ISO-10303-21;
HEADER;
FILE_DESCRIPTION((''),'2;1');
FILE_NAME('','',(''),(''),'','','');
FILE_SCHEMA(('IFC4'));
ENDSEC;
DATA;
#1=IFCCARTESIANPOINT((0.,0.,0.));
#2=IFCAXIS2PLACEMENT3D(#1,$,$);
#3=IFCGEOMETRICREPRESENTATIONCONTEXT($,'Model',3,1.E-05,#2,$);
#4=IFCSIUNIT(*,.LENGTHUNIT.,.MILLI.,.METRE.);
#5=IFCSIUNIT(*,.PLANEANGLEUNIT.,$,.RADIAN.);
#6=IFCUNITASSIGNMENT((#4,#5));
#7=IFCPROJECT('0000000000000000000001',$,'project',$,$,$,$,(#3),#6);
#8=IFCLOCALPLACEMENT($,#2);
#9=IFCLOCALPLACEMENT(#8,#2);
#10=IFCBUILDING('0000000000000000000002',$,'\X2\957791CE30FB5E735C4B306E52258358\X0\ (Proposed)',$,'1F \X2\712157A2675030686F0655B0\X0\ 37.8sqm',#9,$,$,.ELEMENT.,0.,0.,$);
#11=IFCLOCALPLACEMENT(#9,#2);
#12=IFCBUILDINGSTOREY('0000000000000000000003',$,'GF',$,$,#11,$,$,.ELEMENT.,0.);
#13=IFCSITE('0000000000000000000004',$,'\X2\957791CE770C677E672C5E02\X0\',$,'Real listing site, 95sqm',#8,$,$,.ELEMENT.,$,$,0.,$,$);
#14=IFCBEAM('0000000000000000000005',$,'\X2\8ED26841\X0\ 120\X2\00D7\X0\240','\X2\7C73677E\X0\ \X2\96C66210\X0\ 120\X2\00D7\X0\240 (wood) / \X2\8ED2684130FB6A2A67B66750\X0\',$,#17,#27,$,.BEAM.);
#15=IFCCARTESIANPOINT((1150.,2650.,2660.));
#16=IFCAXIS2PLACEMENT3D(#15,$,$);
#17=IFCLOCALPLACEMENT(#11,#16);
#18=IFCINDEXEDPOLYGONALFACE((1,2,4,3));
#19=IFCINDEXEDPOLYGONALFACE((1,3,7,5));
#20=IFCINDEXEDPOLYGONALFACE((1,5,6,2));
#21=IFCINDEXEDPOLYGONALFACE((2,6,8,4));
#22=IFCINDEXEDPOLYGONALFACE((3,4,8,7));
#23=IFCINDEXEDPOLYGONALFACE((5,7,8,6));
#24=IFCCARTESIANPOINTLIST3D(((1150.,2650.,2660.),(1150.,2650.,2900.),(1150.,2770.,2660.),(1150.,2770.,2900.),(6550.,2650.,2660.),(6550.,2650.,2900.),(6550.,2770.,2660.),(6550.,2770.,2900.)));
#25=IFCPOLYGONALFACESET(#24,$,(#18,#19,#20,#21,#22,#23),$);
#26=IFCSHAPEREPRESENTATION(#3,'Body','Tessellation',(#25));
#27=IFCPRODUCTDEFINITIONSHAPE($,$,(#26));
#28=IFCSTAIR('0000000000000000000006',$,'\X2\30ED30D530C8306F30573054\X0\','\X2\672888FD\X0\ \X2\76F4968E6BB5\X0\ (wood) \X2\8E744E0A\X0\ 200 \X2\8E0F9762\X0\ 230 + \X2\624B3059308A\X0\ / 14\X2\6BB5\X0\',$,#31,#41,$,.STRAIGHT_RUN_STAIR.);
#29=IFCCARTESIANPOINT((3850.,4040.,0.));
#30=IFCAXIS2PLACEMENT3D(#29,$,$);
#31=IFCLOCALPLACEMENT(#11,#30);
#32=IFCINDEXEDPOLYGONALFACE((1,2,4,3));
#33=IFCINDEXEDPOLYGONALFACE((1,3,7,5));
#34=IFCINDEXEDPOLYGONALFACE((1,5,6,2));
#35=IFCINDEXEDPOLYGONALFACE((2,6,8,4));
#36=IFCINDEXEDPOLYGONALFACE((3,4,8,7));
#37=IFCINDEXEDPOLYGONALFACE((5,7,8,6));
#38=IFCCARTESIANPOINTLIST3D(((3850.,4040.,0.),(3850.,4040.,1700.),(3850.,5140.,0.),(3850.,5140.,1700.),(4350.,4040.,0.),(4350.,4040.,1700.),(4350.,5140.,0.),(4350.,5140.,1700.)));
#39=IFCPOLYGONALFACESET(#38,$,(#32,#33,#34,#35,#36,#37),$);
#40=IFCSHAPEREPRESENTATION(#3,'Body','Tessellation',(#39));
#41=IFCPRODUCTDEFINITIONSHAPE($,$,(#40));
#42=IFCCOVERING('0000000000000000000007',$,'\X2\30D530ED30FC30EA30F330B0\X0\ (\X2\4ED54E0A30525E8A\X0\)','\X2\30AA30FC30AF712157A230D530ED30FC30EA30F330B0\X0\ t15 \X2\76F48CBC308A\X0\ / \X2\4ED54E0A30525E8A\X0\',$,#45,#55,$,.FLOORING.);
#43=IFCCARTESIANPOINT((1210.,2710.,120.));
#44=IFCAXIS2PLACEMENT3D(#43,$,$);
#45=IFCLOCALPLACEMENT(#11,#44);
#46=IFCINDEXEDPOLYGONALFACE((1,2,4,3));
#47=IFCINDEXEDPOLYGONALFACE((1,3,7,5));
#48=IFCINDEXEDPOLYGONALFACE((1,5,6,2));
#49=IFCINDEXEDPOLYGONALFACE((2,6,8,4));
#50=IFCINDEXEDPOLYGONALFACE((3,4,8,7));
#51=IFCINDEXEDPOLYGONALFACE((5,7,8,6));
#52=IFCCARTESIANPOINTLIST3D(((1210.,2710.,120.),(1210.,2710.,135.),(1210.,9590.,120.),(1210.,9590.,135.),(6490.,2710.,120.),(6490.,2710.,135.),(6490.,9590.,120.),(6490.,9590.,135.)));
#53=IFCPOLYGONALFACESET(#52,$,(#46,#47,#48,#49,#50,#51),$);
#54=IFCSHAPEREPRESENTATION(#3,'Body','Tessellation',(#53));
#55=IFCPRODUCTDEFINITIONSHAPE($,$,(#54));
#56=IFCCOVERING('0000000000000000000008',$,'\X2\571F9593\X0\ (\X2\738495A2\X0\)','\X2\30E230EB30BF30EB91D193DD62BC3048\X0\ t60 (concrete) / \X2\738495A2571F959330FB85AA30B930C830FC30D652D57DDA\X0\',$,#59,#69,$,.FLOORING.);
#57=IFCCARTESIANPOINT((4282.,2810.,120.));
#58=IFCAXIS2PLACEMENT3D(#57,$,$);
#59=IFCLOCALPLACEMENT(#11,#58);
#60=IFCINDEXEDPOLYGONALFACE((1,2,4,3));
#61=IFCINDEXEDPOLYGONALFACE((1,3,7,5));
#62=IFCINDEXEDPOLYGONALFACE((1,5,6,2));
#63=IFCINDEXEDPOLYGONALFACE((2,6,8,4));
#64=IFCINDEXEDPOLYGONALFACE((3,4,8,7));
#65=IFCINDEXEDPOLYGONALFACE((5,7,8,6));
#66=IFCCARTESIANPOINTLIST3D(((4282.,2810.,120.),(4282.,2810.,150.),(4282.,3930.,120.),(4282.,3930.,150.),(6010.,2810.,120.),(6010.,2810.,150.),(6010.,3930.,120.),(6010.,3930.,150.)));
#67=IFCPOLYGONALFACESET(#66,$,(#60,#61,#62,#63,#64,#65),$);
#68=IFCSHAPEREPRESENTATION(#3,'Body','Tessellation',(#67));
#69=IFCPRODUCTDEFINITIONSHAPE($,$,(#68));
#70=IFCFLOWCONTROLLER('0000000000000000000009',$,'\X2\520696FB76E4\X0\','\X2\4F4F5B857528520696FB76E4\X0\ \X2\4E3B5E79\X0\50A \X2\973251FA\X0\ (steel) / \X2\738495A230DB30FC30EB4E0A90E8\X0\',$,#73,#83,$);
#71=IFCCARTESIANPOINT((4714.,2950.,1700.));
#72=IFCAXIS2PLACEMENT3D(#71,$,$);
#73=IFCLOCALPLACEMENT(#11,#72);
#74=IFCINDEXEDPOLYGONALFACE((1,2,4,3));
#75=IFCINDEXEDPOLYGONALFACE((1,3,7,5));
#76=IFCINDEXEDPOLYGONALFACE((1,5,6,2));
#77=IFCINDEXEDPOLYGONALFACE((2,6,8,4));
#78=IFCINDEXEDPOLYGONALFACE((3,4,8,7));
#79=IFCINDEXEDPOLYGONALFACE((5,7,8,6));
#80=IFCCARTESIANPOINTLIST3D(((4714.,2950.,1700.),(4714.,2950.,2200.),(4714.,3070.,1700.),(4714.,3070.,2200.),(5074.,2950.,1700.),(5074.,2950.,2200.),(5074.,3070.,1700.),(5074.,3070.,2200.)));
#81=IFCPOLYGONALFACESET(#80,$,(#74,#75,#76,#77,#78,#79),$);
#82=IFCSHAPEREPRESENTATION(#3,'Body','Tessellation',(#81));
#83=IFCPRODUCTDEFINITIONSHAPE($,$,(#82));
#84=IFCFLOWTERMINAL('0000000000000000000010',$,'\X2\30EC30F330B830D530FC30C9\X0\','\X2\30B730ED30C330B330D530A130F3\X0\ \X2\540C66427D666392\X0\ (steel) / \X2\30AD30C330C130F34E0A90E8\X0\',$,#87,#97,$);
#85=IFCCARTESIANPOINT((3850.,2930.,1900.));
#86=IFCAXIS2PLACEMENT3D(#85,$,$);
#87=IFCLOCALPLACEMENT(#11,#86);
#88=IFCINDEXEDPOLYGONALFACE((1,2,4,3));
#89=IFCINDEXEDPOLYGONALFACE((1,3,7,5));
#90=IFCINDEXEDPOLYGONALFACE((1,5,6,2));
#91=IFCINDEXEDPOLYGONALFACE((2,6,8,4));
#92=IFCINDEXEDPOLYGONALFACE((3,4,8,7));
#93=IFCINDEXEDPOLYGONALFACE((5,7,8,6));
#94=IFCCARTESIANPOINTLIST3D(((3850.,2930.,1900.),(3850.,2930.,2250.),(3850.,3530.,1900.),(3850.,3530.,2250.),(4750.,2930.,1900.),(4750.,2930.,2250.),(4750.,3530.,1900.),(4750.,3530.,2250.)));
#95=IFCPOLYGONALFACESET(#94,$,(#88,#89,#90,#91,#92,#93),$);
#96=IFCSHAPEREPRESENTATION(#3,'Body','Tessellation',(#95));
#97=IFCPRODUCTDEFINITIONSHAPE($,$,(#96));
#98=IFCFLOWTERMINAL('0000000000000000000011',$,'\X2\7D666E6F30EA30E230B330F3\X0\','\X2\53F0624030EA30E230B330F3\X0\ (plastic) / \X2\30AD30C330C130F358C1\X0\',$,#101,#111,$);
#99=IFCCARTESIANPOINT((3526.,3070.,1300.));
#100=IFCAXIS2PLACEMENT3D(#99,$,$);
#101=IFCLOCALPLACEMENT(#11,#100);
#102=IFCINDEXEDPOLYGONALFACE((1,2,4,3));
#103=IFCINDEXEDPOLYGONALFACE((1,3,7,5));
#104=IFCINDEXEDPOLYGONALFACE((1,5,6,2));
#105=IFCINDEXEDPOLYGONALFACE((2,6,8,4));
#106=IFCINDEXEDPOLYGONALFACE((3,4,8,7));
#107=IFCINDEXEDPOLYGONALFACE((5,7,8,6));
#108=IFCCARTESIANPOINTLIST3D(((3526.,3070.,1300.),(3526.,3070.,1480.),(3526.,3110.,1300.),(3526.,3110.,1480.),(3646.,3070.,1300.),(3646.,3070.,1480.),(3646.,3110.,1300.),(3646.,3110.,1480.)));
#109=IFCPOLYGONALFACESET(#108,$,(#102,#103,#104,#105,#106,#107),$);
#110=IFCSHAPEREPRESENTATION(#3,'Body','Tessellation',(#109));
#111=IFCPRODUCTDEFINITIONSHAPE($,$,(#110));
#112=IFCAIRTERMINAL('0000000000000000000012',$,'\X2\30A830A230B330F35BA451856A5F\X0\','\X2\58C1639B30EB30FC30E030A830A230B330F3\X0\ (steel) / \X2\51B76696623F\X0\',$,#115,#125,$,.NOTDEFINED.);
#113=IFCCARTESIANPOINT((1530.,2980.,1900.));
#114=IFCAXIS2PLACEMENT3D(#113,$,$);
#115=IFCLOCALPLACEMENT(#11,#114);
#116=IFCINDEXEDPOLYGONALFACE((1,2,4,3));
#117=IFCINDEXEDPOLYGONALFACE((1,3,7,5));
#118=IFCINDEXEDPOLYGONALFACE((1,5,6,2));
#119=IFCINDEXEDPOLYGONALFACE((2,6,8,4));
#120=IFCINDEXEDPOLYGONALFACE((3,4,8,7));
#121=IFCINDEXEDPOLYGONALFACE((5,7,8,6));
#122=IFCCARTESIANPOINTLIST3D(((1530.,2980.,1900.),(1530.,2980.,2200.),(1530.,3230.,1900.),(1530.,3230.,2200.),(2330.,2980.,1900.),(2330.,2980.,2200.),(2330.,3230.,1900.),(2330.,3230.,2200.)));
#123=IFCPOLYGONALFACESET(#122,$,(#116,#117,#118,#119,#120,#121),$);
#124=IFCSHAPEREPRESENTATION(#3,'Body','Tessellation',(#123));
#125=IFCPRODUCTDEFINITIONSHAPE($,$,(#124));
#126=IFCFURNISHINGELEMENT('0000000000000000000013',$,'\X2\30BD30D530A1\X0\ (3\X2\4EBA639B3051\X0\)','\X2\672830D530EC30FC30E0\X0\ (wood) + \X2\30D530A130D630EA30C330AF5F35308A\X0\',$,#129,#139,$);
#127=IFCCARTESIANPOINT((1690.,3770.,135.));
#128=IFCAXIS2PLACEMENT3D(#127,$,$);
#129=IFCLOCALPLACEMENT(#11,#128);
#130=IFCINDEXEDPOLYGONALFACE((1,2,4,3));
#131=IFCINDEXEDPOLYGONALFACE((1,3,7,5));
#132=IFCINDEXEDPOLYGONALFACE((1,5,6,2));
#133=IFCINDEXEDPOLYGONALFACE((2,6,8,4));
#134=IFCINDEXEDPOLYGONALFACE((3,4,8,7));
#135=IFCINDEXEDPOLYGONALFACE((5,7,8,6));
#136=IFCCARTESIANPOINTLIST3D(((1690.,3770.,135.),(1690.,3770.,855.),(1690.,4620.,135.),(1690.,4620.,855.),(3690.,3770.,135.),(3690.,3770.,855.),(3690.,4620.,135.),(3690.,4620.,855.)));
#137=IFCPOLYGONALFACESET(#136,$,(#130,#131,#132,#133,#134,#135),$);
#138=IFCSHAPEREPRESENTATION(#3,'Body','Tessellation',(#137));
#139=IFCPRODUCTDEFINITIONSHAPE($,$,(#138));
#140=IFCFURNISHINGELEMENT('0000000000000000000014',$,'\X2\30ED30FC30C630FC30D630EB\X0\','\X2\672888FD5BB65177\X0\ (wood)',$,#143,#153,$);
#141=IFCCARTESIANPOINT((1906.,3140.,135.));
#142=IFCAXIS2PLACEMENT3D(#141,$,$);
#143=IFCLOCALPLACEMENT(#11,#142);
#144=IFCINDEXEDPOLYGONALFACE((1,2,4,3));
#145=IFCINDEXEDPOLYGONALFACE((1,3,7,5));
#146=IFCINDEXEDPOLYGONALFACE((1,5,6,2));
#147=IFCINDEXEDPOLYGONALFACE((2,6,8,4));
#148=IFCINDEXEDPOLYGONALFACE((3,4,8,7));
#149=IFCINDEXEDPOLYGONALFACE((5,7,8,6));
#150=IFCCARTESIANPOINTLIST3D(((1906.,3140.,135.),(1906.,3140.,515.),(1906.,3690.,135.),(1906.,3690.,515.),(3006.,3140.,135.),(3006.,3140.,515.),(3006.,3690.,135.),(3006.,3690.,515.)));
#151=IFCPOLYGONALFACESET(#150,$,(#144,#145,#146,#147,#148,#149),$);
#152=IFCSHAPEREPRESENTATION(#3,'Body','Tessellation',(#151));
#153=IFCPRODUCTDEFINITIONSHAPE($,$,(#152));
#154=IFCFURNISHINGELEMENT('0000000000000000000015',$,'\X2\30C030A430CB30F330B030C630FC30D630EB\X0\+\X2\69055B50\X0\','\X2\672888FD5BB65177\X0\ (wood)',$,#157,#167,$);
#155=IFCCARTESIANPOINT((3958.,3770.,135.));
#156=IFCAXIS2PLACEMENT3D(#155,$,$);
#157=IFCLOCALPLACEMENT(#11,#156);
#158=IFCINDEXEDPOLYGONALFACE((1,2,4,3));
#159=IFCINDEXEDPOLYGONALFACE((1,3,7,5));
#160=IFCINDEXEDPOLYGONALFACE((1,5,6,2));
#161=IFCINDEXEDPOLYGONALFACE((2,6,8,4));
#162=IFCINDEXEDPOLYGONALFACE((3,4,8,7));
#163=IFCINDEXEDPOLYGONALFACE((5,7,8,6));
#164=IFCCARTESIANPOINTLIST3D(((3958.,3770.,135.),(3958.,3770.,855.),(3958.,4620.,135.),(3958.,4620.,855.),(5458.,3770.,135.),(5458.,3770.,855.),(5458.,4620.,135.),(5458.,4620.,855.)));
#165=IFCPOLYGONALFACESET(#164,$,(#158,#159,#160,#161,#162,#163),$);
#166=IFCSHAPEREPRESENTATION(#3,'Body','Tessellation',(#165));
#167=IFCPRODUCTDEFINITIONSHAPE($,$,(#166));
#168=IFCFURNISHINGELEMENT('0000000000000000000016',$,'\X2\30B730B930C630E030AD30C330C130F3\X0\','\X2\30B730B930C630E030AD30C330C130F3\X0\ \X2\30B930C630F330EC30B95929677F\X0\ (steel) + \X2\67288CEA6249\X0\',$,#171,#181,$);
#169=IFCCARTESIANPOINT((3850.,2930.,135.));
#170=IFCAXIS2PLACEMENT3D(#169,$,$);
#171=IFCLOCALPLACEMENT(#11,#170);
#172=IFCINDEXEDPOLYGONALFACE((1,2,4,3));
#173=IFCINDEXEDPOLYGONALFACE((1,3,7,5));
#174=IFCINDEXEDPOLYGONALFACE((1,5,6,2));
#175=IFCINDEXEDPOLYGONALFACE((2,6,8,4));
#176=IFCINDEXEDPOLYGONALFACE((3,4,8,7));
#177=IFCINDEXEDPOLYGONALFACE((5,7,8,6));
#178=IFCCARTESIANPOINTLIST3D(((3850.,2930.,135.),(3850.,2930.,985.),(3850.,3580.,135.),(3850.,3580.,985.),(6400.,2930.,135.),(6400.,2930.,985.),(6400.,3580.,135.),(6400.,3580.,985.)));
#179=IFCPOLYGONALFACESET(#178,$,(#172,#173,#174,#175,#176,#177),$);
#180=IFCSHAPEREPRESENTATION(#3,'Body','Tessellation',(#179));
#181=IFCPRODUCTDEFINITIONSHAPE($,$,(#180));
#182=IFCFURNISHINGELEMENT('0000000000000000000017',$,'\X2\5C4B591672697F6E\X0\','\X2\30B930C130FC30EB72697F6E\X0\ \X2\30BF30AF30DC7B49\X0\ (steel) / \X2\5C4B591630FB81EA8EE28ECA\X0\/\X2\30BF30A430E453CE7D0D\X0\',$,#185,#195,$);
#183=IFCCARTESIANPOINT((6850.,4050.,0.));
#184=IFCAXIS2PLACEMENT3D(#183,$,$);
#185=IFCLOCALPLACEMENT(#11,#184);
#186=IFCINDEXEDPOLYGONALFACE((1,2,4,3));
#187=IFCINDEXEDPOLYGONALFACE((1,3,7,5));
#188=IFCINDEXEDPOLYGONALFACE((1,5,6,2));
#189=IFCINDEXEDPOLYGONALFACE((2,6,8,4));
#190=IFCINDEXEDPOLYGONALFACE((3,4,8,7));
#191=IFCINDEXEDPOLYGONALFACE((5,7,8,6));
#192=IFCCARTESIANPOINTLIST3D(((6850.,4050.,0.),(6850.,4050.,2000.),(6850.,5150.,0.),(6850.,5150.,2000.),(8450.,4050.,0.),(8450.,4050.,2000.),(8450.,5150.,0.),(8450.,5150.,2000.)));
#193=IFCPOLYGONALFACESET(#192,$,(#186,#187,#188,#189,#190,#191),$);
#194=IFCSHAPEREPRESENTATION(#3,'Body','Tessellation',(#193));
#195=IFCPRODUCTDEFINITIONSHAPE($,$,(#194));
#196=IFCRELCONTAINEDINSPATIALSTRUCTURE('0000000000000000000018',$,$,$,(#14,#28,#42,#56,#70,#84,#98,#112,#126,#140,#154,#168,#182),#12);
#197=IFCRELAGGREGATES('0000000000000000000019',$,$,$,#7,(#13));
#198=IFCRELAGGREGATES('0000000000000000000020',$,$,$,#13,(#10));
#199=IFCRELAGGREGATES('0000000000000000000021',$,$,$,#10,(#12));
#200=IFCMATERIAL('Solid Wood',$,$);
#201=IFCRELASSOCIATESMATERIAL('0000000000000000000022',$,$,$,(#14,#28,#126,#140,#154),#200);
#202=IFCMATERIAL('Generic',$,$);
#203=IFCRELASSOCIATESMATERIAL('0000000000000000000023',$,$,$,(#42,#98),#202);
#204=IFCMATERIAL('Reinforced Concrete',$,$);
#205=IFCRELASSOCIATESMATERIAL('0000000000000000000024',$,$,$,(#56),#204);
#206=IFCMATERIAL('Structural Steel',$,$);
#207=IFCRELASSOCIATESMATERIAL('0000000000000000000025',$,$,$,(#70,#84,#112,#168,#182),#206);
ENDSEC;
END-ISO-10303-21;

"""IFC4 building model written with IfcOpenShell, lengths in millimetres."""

from ifc_helpers import new_model, si_unit, frame, frame_2d, origin, place, context, project, spatial, rectangle, extrude, material, element, save


model = new_model("IFC4")

# Units and contexts
model_context = context("Model", 3, precision=1e-05, world=origin())
ifc_project = project(units=[si_unit("LENGTHUNIT", "METRE", prefix="MILLI"), si_unit("PLANEANGLEUNIT", "RADIAN")], contexts=[model_context])

# Site, building, storey
site_placement = place(None, origin())
site = spatial("IfcSite", under=ifc_project, at=site_placement, Name="長野県松本市", ObjectType="Real listing site, 95sqm", CompositionType="ELEMENT", RefElevation=0.0)
building_placement = place(site_placement, origin())
building = spatial("IfcBuilding", under=site, at=building_placement, Name="長野・平屋の別荘 (Proposed)", ObjectType="1F 無垢材と漆喰 37.8sqm", CompositionType="ELEMENT", ElevationOfRefHeight=0.0, ElevationOfTerrain=0.0)
storey_placement = place(building_placement, origin())
storey = spatial("IfcBuildingStorey", under=building, at=storey_placement, Name="GF", CompositionType="ELEMENT", Elevation=0.0)

# Beam
ifc_material_1 = material(Name="Solid Wood")
beam_1_placement = place(storey_placement, frame((1150.0, 2650.0, 2660.0)))
element("IfcBeam", 1, at=beam_1_placement, inside=storey, material=ifc_material_1, Name="軒桁 120×240", Description="米松 集成 120×240 (wood) / 軒桁・横架材", PredefinedType="BEAM", context=model_context, shape_type="SweptSolid", body=[
    extrude(rectangle(XDim=5400.0, YDim=120.0, at=frame_2d((2700.0, 60.0))), frame((1150.0, 2650.0, 2660.0)), (0.0, 0.0, 1.0), 240.0),
])

# Stair
stair_placement = place(storey_placement, frame((3850.0, 4040.0, 0.0)))
element("IfcStair", 2, at=stair_placement, inside=storey, material=ifc_material_1, Name="ロフトはしご", Description="木製 直階段 (wood) 蹴上 200 踏面 230 + 手すり / 14段", PredefinedType="STRAIGHT_RUN_STAIR", context=model_context, shape_type="SweptSolid", body=[
    extrude(rectangle(XDim=500.0, YDim=1100.0, at=frame_2d((250.0, 550.0))), frame((3850.0, 4040.0, 0.0)), (0.0, 0.0, 1.0), 1700.0),
])

# Coverings
ifc_material_2 = material(Name="Generic")
covering_1_placement = place(storey_placement, frame((1210.0, 2710.0, 120.0)))
element("IfcCovering", 3, at=covering_1_placement, inside=storey, material=ifc_material_2, Name="フローリング (仕上げ床)", Description="オーク無垢フローリング t15 直貼り / 仕上げ床", PredefinedType="FLOORING", context=model_context, shape_type="SweptSolid", body=[
    extrude(rectangle(XDim=5280.0, YDim=6880.0, at=frame_2d((2640.0, 3440.0))), frame((1210.0, 2710.0, 120.0)), (0.0, 0.0, 1.0), 15.0),
])
ifc_material_3 = material(Name="Reinforced Concrete")
covering_2_placement = place(storey_placement, frame((4282.0, 2810.0, 120.0)))
element("IfcCovering", 4, at=covering_2_placement, inside=storey, material=ifc_material_3, Name="土間 (玄関)", Description="モルタル金鏝押え t60 (concrete) / 玄関土間・薪ストーブ動線", PredefinedType="FLOORING", context=model_context, shape_type="SweptSolid", body=[
    extrude(rectangle(XDim=1728.0, YDim=1120.0, at=frame_2d((864.0, 560.0))), frame((4282.0, 2810.0, 120.0)), (0.0, 0.0, 1.0), 30.0),
])

# Flow controller
ifc_material_4 = material(Name="Structural Steel")
flow_controller_placement = place(storey_placement, frame((4714.0, 2950.0, 1700.0)))
element("IfcFlowController", 5, at=flow_controller_placement, inside=storey, material=ifc_material_4, Name="分電盤", Description="住宅用分電盤 主幹50A 露出 (steel) / 玄関ホール上部", context=model_context, shape_type="SweptSolid", body=[
    extrude(rectangle(XDim=360.0, YDim=120.0, at=frame_2d((180.0, 60.0))), frame((4714.0, 2950.0, 1700.0)), (0.0, 0.0, 1.0), 500.0),
])

# Flow terminals
flow_terminal_1_placement = place(storey_placement, frame((3850.0, 2930.0, 1900.0)))
element("IfcFlowTerminal", 6, at=flow_terminal_1_placement, inside=storey, material=ifc_material_4, Name="レンジフード", Description="シロッコファン 同時給排 (steel) / キッチン上部", context=model_context, shape_type="SweptSolid", body=[
    extrude(rectangle(XDim=900.0, YDim=600.0, at=frame_2d((450.0, 300.0))), frame((3850.0, 2930.0, 1900.0)), (0.0, 0.0, 1.0), 350.0),
])
flow_terminal_2_placement = place(storey_placement, frame((3526.0, 3070.0, 1300.0)))
element("IfcFlowTerminal", 7, at=flow_terminal_2_placement, inside=storey, material=ifc_material_2, Name="給湯リモコン", Description="台所リモコン (plastic) / キッチン壁", context=model_context, shape_type="SweptSolid", body=[
    extrude(rectangle(XDim=120.0, YDim=40.0, at=frame_2d((60.0, 20.0))), frame((3526.0, 3070.0, 1300.0)), (0.0, 0.0, 1.0), 180.0),
])

# Air terminal
air_terminal_placement = place(storey_placement, frame((1530.0, 2980.0, 1900.0)))
element("IfcAirTerminal", 8, at=air_terminal_placement, inside=storey, material=ifc_material_4, Name="エアコン室内機", Description="壁掛ルームエアコン (steel) / 冷暖房", PredefinedType="NOTDEFINED", context=model_context, shape_type="SweptSolid", body=[
    extrude(rectangle(XDim=800.0, YDim=250.0, at=frame_2d((400.0, 125.0))), frame((1530.0, 2980.0, 1900.0)), (0.0, 0.0, 1.0), 300.0),
])

# Furnishing elements
furnishing_1_placement = place(storey_placement, frame((1690.0, 3770.0, 135.0)))
element("IfcFurnishingElement", 9, at=furnishing_1_placement, inside=storey, material=ifc_material_1, Name="ソファ (3人掛け)", Description="木フレーム (wood) + ファブリック張り", context=model_context, shape_type="SweptSolid", body=[
    extrude(rectangle(XDim=2000.0, YDim=850.0, at=frame_2d((1000.0, 425.0))), frame((1690.0, 3770.0, 135.0)), (0.0, 0.0, 1.0), 720.0),
])
furnishing_2_placement = place(storey_placement, frame((1906.0, 3140.0, 135.0)))
element("IfcFurnishingElement", 10, at=furnishing_2_placement, inside=storey, material=ifc_material_1, Name="ローテーブル", Description="木製家具 (wood)", context=model_context, shape_type="SweptSolid", body=[
    extrude(rectangle(XDim=1100.0, YDim=550.0, at=frame_2d((550.0, 275.0))), frame((1906.0, 3140.0, 135.0)), (0.0, 0.0, 1.0), 380.0),
])
furnishing_3_placement = place(storey_placement, frame((3958.0, 3770.0, 135.0)))
element("IfcFurnishingElement", 11, at=furnishing_3_placement, inside=storey, material=ifc_material_1, Name="ダイニングテーブル+椅子", Description="木製家具 (wood)", context=model_context, shape_type="SweptSolid", body=[
    extrude(rectangle(XDim=1500.0, YDim=850.0, at=frame_2d((750.0, 425.0))), frame((3958.0, 3770.0, 135.0)), (0.0, 0.0, 1.0), 720.0),
])
furnishing_4_placement = place(storey_placement, frame((3850.0, 2930.0, 135.0)))
element("IfcFurnishingElement", 12, at=furnishing_4_placement, inside=storey, material=ifc_material_4, Name="システムキッチン", Description="システムキッチン ステンレス天板 (steel) + 木質扉", context=model_context, shape_type="SweptSolid", body=[
    extrude(rectangle(XDim=2550.0, YDim=650.0, at=frame_2d((1275.0, 325.0))), frame((3850.0, 2930.0, 135.0)), (0.0, 0.0, 1.0), 850.0),
])
furnishing_5_placement = place(storey_placement, frame((6850.0, 4050.0, 0.0)))
element("IfcFurnishingElement", 13, at=furnishing_5_placement, inside=storey, material=ifc_material_4, Name="屋外物置", Description="スチール物置 タクボ等 (steel) / 屋外・自転車/タイヤ収納", context=model_context, shape_type="SweptSolid", body=[
    extrude(rectangle(XDim=1600.0, YDim=1100.0, at=frame_2d((800.0, 550.0))), frame((6850.0, 4050.0, 0.0)), (0.0, 0.0, 1.0), 2000.0),
])

save(model, "model.ifc")
